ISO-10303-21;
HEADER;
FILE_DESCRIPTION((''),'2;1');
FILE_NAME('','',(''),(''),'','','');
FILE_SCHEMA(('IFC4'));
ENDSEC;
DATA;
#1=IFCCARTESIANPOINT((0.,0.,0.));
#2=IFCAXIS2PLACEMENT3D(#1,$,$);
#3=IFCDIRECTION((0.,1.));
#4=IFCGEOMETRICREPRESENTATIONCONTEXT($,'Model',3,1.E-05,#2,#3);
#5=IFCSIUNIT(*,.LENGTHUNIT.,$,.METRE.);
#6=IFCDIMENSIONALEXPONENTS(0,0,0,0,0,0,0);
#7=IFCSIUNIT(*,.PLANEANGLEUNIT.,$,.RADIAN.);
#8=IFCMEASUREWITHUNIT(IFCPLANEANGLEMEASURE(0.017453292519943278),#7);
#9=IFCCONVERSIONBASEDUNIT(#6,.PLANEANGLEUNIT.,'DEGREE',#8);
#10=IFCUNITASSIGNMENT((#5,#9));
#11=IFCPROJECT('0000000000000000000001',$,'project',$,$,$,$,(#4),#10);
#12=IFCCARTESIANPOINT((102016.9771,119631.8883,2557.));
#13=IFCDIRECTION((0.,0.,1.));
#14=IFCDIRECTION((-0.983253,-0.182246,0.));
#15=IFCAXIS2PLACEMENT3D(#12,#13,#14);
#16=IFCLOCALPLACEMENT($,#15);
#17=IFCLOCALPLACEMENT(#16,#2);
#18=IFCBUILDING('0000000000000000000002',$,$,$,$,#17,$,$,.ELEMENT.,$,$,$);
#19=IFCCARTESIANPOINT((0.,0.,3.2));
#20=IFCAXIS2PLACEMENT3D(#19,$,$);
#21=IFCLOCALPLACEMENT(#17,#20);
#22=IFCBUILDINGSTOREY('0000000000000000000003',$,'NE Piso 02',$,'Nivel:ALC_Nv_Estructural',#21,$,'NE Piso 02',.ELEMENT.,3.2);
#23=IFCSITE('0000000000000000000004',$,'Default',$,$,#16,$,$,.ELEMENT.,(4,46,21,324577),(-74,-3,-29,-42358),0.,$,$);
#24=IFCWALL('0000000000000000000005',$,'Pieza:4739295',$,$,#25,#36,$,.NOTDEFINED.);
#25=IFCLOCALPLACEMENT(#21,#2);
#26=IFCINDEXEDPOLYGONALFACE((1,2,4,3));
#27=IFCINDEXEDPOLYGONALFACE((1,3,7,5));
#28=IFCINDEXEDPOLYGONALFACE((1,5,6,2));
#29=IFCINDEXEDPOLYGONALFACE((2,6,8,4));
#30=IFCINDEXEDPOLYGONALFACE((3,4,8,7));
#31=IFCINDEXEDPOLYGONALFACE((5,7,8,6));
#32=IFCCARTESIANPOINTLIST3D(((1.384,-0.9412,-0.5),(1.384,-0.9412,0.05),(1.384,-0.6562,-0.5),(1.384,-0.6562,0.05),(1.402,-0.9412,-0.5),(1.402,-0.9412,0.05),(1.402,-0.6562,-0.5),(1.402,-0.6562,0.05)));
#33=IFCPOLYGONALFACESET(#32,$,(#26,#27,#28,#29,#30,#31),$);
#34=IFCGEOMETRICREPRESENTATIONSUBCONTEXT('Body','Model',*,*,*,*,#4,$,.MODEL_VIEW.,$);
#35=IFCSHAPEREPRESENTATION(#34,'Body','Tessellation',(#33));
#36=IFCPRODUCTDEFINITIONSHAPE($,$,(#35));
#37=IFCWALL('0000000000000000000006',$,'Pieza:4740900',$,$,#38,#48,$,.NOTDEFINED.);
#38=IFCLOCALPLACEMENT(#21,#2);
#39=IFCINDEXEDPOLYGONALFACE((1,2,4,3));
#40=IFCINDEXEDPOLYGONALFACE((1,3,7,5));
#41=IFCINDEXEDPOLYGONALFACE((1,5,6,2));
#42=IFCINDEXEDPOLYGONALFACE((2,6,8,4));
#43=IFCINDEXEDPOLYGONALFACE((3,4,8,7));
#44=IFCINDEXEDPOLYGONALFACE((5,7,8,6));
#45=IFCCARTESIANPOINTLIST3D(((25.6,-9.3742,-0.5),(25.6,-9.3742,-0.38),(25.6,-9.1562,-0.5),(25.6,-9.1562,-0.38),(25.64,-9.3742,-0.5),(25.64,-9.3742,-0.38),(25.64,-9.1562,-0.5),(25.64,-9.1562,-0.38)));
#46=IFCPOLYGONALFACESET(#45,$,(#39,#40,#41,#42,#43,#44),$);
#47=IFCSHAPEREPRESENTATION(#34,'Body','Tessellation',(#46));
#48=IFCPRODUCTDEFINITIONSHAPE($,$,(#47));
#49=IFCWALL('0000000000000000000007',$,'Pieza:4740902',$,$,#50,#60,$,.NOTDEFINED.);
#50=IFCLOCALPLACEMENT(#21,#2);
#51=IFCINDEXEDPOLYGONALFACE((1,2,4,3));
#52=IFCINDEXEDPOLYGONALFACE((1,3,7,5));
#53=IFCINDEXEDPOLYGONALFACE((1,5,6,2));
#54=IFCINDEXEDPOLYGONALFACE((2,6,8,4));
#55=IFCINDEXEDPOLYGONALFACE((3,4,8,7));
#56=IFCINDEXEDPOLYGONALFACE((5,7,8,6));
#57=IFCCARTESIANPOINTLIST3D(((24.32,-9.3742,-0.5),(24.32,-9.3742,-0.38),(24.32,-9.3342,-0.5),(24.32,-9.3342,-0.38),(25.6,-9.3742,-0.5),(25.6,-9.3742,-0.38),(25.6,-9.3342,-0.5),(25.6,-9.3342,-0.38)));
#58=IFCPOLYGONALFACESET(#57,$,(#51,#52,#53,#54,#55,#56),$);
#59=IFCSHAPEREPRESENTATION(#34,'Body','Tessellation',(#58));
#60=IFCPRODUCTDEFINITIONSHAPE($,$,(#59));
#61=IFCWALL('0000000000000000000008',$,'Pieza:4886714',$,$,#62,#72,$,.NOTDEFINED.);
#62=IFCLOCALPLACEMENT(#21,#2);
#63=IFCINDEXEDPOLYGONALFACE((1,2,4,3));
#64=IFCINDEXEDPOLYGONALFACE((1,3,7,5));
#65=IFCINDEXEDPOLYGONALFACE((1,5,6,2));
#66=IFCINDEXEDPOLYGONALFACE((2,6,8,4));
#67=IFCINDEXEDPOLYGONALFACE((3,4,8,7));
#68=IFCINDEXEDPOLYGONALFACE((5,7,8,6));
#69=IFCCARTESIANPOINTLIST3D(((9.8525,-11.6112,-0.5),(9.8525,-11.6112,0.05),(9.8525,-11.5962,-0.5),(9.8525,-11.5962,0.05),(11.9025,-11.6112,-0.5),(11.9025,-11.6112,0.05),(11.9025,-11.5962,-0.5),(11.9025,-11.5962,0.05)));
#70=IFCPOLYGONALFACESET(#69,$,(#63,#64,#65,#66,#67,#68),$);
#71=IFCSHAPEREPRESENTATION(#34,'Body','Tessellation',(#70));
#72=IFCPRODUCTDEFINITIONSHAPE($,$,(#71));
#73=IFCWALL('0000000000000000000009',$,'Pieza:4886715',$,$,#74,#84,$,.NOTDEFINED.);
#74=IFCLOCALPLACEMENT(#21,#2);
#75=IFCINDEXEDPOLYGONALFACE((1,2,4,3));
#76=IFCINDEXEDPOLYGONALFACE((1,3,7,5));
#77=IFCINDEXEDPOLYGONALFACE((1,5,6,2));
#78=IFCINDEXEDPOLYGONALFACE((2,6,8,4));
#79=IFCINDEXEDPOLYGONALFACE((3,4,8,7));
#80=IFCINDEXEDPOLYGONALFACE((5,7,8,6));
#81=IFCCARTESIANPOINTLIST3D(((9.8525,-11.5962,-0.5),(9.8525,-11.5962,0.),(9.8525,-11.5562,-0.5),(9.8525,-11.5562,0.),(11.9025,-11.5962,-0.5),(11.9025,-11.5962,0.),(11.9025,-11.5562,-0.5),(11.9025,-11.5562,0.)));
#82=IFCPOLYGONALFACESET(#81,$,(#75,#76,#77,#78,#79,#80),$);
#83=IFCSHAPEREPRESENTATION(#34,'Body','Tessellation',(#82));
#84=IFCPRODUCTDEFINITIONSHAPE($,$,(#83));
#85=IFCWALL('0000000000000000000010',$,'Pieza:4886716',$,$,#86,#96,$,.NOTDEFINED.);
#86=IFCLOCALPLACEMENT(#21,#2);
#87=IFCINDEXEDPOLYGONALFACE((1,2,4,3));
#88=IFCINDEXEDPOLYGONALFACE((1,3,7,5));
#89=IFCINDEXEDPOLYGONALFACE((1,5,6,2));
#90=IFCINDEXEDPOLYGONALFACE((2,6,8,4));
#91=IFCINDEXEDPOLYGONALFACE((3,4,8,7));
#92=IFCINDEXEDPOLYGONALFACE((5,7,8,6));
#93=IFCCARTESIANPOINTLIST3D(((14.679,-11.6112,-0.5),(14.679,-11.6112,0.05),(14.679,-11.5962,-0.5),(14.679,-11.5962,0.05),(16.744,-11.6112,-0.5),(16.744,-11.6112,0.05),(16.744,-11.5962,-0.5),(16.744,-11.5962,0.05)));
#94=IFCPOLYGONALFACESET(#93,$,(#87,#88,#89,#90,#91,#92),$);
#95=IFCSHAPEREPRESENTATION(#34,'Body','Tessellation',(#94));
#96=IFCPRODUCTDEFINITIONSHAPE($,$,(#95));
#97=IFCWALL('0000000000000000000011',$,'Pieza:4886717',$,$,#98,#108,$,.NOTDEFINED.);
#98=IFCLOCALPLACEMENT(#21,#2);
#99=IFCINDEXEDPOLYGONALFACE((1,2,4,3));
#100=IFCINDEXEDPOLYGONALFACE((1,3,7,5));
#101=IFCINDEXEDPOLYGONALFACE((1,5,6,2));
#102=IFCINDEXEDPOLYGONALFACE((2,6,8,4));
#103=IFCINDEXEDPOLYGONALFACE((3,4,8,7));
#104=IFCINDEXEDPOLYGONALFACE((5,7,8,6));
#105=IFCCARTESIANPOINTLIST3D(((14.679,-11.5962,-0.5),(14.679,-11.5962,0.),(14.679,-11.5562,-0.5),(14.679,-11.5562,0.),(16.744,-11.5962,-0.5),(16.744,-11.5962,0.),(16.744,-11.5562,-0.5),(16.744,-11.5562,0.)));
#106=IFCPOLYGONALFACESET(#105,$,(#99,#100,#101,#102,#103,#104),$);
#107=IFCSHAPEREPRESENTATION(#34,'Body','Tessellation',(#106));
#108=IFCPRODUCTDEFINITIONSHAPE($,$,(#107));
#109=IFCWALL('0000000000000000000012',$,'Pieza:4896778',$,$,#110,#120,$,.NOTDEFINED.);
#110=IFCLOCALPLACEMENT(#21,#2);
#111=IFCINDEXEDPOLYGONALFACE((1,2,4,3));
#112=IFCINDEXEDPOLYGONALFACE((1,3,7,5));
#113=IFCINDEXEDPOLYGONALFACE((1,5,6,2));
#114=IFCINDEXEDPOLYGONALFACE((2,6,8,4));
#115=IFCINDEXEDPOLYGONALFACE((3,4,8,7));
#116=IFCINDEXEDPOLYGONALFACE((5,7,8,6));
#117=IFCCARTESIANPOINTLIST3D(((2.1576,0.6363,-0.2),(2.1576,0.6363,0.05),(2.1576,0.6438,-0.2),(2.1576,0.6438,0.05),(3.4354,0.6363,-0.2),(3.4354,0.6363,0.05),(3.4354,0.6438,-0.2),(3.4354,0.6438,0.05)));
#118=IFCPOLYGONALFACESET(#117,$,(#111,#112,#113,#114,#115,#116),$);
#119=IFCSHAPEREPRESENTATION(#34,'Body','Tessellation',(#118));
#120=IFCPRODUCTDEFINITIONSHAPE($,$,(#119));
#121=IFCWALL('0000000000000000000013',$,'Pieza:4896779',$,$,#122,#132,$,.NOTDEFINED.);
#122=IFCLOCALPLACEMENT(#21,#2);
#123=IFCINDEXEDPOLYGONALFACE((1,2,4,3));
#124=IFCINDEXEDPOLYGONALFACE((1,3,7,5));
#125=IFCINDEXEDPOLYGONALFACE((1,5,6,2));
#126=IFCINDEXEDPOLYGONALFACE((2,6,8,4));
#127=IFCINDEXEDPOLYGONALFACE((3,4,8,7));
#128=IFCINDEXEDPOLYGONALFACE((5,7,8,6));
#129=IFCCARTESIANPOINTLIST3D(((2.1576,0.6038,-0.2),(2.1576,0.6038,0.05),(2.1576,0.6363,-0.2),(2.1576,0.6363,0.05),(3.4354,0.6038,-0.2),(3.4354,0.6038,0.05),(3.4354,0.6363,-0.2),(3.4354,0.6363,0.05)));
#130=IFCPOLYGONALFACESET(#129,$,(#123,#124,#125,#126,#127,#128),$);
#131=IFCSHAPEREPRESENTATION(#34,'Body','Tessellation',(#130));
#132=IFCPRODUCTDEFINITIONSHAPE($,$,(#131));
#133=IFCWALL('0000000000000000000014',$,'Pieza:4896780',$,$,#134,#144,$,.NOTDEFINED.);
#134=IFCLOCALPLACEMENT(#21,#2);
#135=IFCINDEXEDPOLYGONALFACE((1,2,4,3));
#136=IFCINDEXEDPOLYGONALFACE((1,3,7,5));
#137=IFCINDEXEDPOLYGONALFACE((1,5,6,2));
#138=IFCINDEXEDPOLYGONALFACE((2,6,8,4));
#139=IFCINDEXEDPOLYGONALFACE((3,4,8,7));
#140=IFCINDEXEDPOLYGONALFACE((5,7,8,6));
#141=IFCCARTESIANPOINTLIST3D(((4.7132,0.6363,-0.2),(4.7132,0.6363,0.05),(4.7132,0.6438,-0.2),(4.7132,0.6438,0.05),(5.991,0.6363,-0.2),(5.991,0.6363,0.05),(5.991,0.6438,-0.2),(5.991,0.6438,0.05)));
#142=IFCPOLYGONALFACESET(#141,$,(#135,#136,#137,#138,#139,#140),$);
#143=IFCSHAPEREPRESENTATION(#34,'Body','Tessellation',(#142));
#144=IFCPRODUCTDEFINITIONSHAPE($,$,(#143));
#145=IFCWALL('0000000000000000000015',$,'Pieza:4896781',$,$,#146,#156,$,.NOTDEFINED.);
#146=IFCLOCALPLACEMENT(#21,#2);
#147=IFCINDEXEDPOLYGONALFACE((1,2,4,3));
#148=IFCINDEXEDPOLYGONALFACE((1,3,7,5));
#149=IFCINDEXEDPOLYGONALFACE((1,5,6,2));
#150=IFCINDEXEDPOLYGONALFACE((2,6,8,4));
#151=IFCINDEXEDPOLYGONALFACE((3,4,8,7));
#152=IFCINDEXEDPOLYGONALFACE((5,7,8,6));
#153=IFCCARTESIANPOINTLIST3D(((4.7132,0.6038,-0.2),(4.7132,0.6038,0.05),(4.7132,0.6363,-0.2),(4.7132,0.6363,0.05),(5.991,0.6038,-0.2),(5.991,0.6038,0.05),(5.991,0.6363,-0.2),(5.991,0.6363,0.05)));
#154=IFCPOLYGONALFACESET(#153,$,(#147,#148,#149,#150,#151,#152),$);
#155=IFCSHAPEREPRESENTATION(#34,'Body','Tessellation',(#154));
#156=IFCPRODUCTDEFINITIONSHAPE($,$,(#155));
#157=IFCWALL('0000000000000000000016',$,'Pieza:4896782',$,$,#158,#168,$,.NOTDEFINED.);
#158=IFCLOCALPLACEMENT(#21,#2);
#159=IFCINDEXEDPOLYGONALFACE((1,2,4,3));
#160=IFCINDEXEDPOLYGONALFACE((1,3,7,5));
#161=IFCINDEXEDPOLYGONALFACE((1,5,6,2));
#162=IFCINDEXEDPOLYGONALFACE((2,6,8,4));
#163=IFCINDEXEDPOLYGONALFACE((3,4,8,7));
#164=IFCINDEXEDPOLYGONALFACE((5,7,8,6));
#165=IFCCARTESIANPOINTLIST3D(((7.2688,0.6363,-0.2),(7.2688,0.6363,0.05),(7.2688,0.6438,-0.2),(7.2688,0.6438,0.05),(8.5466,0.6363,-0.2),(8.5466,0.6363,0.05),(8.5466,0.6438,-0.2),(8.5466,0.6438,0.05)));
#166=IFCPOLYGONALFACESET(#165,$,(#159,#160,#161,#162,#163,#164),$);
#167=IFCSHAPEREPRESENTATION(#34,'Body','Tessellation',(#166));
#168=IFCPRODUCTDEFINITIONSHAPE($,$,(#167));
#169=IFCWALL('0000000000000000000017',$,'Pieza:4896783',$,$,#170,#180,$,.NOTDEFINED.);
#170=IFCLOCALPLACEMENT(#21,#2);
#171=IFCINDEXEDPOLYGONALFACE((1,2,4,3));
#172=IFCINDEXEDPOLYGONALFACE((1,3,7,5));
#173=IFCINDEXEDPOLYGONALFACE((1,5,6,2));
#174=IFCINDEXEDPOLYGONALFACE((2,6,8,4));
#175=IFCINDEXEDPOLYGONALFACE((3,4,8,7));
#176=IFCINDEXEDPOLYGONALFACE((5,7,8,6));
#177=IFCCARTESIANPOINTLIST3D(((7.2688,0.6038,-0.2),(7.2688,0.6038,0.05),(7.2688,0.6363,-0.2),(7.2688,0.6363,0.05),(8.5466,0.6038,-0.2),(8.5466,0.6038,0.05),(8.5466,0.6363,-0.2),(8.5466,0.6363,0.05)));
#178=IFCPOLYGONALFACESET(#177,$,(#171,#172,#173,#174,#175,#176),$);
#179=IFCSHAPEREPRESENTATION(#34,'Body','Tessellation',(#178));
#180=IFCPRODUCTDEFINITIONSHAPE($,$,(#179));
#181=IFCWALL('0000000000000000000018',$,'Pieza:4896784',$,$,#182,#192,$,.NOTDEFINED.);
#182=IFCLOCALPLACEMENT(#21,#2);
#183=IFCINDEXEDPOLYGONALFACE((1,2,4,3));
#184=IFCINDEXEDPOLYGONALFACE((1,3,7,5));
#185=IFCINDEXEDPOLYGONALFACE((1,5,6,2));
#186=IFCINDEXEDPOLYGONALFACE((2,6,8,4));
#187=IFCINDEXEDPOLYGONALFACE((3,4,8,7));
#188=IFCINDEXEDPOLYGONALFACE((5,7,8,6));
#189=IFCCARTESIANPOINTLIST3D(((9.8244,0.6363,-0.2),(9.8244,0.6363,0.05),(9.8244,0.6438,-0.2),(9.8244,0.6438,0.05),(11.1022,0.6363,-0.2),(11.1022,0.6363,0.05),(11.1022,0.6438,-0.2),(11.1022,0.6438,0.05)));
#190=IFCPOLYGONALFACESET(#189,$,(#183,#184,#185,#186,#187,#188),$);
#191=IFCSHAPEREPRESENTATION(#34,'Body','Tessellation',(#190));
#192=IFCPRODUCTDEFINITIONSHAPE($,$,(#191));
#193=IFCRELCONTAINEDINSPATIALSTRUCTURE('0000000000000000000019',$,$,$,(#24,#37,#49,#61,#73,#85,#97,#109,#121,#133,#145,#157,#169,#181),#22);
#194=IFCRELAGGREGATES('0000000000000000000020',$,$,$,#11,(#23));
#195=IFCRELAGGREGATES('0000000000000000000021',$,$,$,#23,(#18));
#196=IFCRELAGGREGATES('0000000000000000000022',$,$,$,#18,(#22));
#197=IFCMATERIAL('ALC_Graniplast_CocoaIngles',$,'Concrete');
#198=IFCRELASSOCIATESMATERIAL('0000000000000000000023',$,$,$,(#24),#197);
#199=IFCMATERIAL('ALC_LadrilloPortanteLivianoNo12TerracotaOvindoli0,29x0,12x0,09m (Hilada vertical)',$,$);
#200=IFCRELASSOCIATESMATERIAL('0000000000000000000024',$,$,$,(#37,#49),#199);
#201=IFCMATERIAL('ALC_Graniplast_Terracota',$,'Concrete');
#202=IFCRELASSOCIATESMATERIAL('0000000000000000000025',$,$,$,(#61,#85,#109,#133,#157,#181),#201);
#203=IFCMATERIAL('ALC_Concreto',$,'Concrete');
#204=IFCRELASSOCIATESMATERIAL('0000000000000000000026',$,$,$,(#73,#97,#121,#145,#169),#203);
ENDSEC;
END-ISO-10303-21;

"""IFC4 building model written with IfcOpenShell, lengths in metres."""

from ifc_helpers import new_model, entity, si_unit, converted_unit, direction, frame, frame_2d, origin, origin_2d_with_axis, place, context, subcontext, project, spatial, rectangle, extrude, material, element, save


model = new_model("IFC4")

# Units and contexts
model_context = context("Model", 3, precision=1e-05, world=origin(), true_north=direction((0.0, 1.0)))
body_context = subcontext(model_context, "Body", "Model", "MODEL_VIEW")
ifc_project = project(units=[si_unit("LENGTHUNIT", "METRE"), converted_unit("PLANEANGLEUNIT", "DEGREE", entity("IfcPlaneAngleMeasure", 0.017453292519943278), si_unit("PLANEANGLEUNIT", "RADIAN"), dimensions=[0, 0, 0, 0, 0, 0, 0])], contexts=[model_context])

# Site, building, storey
site_placement = place(None, frame((102016.9771, 119631.8883, 2557.0), z_axis=(0.0, 0.0, 1.0), x_axis=(-0.983253, -0.182246, 0.0)))
site = spatial("IfcSite", under=ifc_project, at=site_placement, Name="Default", CompositionType="ELEMENT", RefLatitude=(4, 46, 21, 324577), RefLongitude=(-74, -3, -29, -42358), RefElevation=0.0)
building_placement = place(site_placement, origin())
building = spatial("IfcBuilding", under=site, at=building_placement, CompositionType="ELEMENT")
storey_placement = place(building_placement, frame((0.0, 0.0, 3.2)))
storey = spatial("IfcBuildingStorey", under=building, at=storey_placement, Name="NE Piso 02", ObjectType="Nivel:ALC_Nv_Estructural", LongName="NE Piso 02", CompositionType="ELEMENT", Elevation=3.2)

# Walls
ifc_material_1 = material(Name="ALC_Graniplast_CocoaIngles", Category="Concrete")
wall_1_placement = place(storey_placement, frame((0.0, 0.0, -0.5)))
element("IfcWall", 1, at=wall_1_placement, inside=storey, material=ifc_material_1, Name="Pieza:4739295", PredefinedType="NOTDEFINED", context=body_context, shape_type="SweptSolid", body=[
    extrude(rectangle(XDim=0.285, YDim=0.018, at=frame_2d((0.0, 0.0), x_axis=(1.0, 0.0))), frame((1.393, -0.7987, 0.0), z_axis=(0.0, 0.0, 1.0), x_axis=(0.0, -1.0, 0.0)), (0.0, 0.0, 1.0), 0.55),
])
ifc_material_2 = material(Name="ALC_LadrilloPortanteLivianoNo12TerracotaOvindoli0,29x0,12x0,09m (Hilada vertical)")
wall_2_placement = place(storey_placement, frame((0.0, 0.0, -0.5)))
element("IfcWall", 2, at=wall_2_placement, inside=storey, material=ifc_material_2, Name="Pieza:4740900", PredefinedType="NOTDEFINED", context=body_context, shape_type="SweptSolid", body=[
    extrude(rectangle(XDim=0.218, YDim=0.04, at=frame_2d((0.0, 0.0), x_axis=(1.0, 0.0))), frame((25.62, -9.2652, 0.0), z_axis=(0.0, 0.0, 1.0), x_axis=(0.0, -1.0, 0.0)), (0.0, 0.0, 1.0), 0.12),
])
wall_3_placement = place(storey_placement, frame((0.0, 0.0, -0.5)))
element("IfcWall", 3, at=wall_3_placement, inside=storey, material=ifc_material_2, Name="Pieza:4740902", PredefinedType="NOTDEFINED", context=body_context, shape_type="SweptSolid", body=[
    extrude(rectangle(XDim=0.04, YDim=1.28, at=frame_2d((0.0, 0.0), x_axis=(1.0, 0.0))), frame((24.96, -9.3542, 0.0), z_axis=(0.0, 0.0, 1.0), x_axis=(0.0, -1.0, 0.0)), (0.0, 0.0, 1.0), 0.12),
])
ifc_material_3 = material(Name="ALC_Graniplast_Terracota", Category="Concrete")
wall_4_placement = place(storey_placement, frame((0.0, 0.0, -0.5)))
element("IfcWall", 4, at=wall_4_placement, inside=storey, material=ifc_material_3, Name="Pieza:4886714", PredefinedType="NOTDEFINED", context=body_context, shape_type="SweptSolid", body=[
    extrude(rectangle(XDim=0.015, YDim=2.05, at=frame_2d((0.0, 0.0), x_axis=(1.0, 0.0))), frame((10.8775, -11.6037, 0.0), z_axis=(0.0, 0.0, 1.0), x_axis=(0.0, -1.0, 0.0)), (0.0, 0.0, 1.0), 0.55),
])
ifc_material_4 = material(Name="ALC_Concreto", Category="Concrete")
wall_5_placement = place(storey_placement, frame((0.0, 0.0, -0.5)))
element("IfcWall", 5, at=wall_5_placement, inside=storey, material=ifc_material_4, Name="Pieza:4886715", PredefinedType="NOTDEFINED", context=body_context, shape_type="SweptSolid", body=[
    extrude(rectangle(XDim=0.04, YDim=2.05, at=frame_2d((0.0, 0.0), x_axis=(1.0, 0.0))), frame((10.8775, -11.5762, 0.0), z_axis=(0.0, 0.0, 1.0), x_axis=(0.0, -1.0, 0.0)), (0.0, 0.0, 1.0), 0.5),
])
wall_6_placement = place(storey_placement, frame((0.0, 0.0, -0.5)))
element("IfcWall", 6, at=wall_6_placement, inside=storey, material=ifc_material_3, Name="Pieza:4886716", PredefinedType="NOTDEFINED", context=body_context, shape_type="SweptSolid", body=[
    extrude(rectangle(XDim=0.015, YDim=2.065, at=frame_2d((0.0, 0.0), x_axis=(1.0, 0.0))), frame((15.7115, -11.6037, 0.0), z_axis=(0.0, 0.0, 1.0), x_axis=(0.0, -1.0, 0.0)), (0.0, 0.0, 1.0), 0.55),
])
wall_7_placement = place(storey_placement, frame((0.0, 0.0, -0.5)))
element("IfcWall", 7, at=wall_7_placement, inside=storey, material=ifc_material_4, Name="Pieza:4886717", PredefinedType="NOTDEFINED", context=body_context, shape_type="SweptSolid", body=[
    extrude(rectangle(XDim=0.04, YDim=2.065, at=frame_2d((0.0, 0.0), x_axis=(1.0, 0.0))), frame((15.7115, -11.5762, 0.0), z_axis=(0.0, 0.0, 1.0), x_axis=(0.0, -1.0, 0.0)), (0.0, 0.0, 1.0), 0.5),
])
wall_8_placement = place(storey_placement, frame((0.0, 0.0, -0.2)))
element("IfcWall", 8, at=wall_8_placement, inside=storey, material=ifc_material_3, Name="Pieza:4896778", PredefinedType="NOTDEFINED", context=body_context, shape_type="SweptSolid", body=[
    extrude(rectangle(XDim=0.0075, YDim=1.2778, at=origin_2d_with_axis()), frame((2.7965, 0.6401, 0.0), z_axis=(0.0, 0.0, 1.0), x_axis=(0.0, -1.0, 0.0)), (0.0, 0.0, 1.0), 0.25),
])
wall_9_placement = place(storey_placement, frame((0.0, 0.0, -0.2)))
element("IfcWall", 9, at=wall_9_placement, inside=storey, material=ifc_material_4, Name="Pieza:4896779", PredefinedType="NOTDEFINED", context=body_context, shape_type="SweptSolid", body=[
    extrude(rectangle(XDim=0.0325, YDim=1.2778, at=frame_2d((0.0, 0.0), x_axis=(1.0, 0.0))), frame((2.7965, 0.6201, 0.0), z_axis=(0.0, 0.0, 1.0), x_axis=(0.0, -1.0, 0.0)), (0.0, 0.0, 1.0), 0.25),
])
wall_10_placement = place(storey_placement, frame((0.0, 0.0, -0.2)))
element("IfcWall", 10, at=wall_10_placement, inside=storey, material=ifc_material_3, Name="Pieza:4896780", PredefinedType="NOTDEFINED", context=body_context, shape_type="SweptSolid", body=[
    extrude(rectangle(XDim=0.0075, YDim=1.2778, at=origin_2d_with_axis()), frame((5.3521, 0.6401, 0.0), z_axis=(0.0, 0.0, 1.0), x_axis=(0.0, -1.0, 0.0)), (0.0, 0.0, 1.0), 0.25),
])
wall_11_placement = place(storey_placement, frame((0.0, 0.0, -0.2)))
element("IfcWall", 11, at=wall_11_placement, inside=storey, material=ifc_material_4, Name="Pieza:4896781", PredefinedType="NOTDEFINED", context=body_context, shape_type="SweptSolid", body=[
    extrude(rectangle(XDim=0.0325, YDim=1.2778, at=frame_2d((0.0, 0.0), x_axis=(1.0, 0.0))), frame((5.3521, 0.6201, 0.0), z_axis=(0.0, 0.0, 1.0), x_axis=(0.0, -1.0, 0.0)), (0.0, 0.0, 1.0), 0.25),
])
wall_12_placement = place(storey_placement, frame((0.0, 0.0, -0.2)))
element("IfcWall", 12, at=wall_12_placement, inside=storey, material=ifc_material_3, Name="Pieza:4896782", PredefinedType="NOTDEFINED", context=body_context, shape_type="SweptSolid", body=[
    extrude(rectangle(XDim=0.0075, YDim=1.2778, at=origin_2d_with_axis()), frame((7.9077, 0.6401, 0.0), z_axis=(0.0, 0.0, 1.0), x_axis=(0.0, -1.0, 0.0)), (0.0, 0.0, 1.0), 0.25),
])
wall_13_placement = place(storey_placement, frame((0.0, 0.0, -0.2)))
element("IfcWall", 13, at=wall_13_placement, inside=storey, material=ifc_material_4, Name="Pieza:4896783", PredefinedType="NOTDEFINED", context=body_context, shape_type="SweptSolid", body=[
    extrude(rectangle(XDim=0.0325, YDim=1.2778, at=origin_2d_with_axis()), frame((7.9077, 0.6201, 0.0), z_axis=(0.0, 0.0, 1.0), x_axis=(0.0, -1.0, 0.0)), (0.0, 0.0, 1.0), 0.25),
])
wall_14_placement = place(storey_placement, frame((0.0, 0.0, -0.2)))
element("IfcWall", 14, at=wall_14_placement, inside=storey, material=ifc_material_3, Name="Pieza:4896784", PredefinedType="NOTDEFINED", context=body_context, shape_type="SweptSolid", body=[
    extrude(rectangle(XDim=0.0075, YDim=1.2778, at=origin_2d_with_axis()), frame((10.4633, 0.6401, 0.0), z_axis=(0.0, 0.0, 1.0), x_axis=(0.0, -1.0, 0.0)), (0.0, 0.0, 1.0), 0.25),
])

save(model, "model.ifc")
